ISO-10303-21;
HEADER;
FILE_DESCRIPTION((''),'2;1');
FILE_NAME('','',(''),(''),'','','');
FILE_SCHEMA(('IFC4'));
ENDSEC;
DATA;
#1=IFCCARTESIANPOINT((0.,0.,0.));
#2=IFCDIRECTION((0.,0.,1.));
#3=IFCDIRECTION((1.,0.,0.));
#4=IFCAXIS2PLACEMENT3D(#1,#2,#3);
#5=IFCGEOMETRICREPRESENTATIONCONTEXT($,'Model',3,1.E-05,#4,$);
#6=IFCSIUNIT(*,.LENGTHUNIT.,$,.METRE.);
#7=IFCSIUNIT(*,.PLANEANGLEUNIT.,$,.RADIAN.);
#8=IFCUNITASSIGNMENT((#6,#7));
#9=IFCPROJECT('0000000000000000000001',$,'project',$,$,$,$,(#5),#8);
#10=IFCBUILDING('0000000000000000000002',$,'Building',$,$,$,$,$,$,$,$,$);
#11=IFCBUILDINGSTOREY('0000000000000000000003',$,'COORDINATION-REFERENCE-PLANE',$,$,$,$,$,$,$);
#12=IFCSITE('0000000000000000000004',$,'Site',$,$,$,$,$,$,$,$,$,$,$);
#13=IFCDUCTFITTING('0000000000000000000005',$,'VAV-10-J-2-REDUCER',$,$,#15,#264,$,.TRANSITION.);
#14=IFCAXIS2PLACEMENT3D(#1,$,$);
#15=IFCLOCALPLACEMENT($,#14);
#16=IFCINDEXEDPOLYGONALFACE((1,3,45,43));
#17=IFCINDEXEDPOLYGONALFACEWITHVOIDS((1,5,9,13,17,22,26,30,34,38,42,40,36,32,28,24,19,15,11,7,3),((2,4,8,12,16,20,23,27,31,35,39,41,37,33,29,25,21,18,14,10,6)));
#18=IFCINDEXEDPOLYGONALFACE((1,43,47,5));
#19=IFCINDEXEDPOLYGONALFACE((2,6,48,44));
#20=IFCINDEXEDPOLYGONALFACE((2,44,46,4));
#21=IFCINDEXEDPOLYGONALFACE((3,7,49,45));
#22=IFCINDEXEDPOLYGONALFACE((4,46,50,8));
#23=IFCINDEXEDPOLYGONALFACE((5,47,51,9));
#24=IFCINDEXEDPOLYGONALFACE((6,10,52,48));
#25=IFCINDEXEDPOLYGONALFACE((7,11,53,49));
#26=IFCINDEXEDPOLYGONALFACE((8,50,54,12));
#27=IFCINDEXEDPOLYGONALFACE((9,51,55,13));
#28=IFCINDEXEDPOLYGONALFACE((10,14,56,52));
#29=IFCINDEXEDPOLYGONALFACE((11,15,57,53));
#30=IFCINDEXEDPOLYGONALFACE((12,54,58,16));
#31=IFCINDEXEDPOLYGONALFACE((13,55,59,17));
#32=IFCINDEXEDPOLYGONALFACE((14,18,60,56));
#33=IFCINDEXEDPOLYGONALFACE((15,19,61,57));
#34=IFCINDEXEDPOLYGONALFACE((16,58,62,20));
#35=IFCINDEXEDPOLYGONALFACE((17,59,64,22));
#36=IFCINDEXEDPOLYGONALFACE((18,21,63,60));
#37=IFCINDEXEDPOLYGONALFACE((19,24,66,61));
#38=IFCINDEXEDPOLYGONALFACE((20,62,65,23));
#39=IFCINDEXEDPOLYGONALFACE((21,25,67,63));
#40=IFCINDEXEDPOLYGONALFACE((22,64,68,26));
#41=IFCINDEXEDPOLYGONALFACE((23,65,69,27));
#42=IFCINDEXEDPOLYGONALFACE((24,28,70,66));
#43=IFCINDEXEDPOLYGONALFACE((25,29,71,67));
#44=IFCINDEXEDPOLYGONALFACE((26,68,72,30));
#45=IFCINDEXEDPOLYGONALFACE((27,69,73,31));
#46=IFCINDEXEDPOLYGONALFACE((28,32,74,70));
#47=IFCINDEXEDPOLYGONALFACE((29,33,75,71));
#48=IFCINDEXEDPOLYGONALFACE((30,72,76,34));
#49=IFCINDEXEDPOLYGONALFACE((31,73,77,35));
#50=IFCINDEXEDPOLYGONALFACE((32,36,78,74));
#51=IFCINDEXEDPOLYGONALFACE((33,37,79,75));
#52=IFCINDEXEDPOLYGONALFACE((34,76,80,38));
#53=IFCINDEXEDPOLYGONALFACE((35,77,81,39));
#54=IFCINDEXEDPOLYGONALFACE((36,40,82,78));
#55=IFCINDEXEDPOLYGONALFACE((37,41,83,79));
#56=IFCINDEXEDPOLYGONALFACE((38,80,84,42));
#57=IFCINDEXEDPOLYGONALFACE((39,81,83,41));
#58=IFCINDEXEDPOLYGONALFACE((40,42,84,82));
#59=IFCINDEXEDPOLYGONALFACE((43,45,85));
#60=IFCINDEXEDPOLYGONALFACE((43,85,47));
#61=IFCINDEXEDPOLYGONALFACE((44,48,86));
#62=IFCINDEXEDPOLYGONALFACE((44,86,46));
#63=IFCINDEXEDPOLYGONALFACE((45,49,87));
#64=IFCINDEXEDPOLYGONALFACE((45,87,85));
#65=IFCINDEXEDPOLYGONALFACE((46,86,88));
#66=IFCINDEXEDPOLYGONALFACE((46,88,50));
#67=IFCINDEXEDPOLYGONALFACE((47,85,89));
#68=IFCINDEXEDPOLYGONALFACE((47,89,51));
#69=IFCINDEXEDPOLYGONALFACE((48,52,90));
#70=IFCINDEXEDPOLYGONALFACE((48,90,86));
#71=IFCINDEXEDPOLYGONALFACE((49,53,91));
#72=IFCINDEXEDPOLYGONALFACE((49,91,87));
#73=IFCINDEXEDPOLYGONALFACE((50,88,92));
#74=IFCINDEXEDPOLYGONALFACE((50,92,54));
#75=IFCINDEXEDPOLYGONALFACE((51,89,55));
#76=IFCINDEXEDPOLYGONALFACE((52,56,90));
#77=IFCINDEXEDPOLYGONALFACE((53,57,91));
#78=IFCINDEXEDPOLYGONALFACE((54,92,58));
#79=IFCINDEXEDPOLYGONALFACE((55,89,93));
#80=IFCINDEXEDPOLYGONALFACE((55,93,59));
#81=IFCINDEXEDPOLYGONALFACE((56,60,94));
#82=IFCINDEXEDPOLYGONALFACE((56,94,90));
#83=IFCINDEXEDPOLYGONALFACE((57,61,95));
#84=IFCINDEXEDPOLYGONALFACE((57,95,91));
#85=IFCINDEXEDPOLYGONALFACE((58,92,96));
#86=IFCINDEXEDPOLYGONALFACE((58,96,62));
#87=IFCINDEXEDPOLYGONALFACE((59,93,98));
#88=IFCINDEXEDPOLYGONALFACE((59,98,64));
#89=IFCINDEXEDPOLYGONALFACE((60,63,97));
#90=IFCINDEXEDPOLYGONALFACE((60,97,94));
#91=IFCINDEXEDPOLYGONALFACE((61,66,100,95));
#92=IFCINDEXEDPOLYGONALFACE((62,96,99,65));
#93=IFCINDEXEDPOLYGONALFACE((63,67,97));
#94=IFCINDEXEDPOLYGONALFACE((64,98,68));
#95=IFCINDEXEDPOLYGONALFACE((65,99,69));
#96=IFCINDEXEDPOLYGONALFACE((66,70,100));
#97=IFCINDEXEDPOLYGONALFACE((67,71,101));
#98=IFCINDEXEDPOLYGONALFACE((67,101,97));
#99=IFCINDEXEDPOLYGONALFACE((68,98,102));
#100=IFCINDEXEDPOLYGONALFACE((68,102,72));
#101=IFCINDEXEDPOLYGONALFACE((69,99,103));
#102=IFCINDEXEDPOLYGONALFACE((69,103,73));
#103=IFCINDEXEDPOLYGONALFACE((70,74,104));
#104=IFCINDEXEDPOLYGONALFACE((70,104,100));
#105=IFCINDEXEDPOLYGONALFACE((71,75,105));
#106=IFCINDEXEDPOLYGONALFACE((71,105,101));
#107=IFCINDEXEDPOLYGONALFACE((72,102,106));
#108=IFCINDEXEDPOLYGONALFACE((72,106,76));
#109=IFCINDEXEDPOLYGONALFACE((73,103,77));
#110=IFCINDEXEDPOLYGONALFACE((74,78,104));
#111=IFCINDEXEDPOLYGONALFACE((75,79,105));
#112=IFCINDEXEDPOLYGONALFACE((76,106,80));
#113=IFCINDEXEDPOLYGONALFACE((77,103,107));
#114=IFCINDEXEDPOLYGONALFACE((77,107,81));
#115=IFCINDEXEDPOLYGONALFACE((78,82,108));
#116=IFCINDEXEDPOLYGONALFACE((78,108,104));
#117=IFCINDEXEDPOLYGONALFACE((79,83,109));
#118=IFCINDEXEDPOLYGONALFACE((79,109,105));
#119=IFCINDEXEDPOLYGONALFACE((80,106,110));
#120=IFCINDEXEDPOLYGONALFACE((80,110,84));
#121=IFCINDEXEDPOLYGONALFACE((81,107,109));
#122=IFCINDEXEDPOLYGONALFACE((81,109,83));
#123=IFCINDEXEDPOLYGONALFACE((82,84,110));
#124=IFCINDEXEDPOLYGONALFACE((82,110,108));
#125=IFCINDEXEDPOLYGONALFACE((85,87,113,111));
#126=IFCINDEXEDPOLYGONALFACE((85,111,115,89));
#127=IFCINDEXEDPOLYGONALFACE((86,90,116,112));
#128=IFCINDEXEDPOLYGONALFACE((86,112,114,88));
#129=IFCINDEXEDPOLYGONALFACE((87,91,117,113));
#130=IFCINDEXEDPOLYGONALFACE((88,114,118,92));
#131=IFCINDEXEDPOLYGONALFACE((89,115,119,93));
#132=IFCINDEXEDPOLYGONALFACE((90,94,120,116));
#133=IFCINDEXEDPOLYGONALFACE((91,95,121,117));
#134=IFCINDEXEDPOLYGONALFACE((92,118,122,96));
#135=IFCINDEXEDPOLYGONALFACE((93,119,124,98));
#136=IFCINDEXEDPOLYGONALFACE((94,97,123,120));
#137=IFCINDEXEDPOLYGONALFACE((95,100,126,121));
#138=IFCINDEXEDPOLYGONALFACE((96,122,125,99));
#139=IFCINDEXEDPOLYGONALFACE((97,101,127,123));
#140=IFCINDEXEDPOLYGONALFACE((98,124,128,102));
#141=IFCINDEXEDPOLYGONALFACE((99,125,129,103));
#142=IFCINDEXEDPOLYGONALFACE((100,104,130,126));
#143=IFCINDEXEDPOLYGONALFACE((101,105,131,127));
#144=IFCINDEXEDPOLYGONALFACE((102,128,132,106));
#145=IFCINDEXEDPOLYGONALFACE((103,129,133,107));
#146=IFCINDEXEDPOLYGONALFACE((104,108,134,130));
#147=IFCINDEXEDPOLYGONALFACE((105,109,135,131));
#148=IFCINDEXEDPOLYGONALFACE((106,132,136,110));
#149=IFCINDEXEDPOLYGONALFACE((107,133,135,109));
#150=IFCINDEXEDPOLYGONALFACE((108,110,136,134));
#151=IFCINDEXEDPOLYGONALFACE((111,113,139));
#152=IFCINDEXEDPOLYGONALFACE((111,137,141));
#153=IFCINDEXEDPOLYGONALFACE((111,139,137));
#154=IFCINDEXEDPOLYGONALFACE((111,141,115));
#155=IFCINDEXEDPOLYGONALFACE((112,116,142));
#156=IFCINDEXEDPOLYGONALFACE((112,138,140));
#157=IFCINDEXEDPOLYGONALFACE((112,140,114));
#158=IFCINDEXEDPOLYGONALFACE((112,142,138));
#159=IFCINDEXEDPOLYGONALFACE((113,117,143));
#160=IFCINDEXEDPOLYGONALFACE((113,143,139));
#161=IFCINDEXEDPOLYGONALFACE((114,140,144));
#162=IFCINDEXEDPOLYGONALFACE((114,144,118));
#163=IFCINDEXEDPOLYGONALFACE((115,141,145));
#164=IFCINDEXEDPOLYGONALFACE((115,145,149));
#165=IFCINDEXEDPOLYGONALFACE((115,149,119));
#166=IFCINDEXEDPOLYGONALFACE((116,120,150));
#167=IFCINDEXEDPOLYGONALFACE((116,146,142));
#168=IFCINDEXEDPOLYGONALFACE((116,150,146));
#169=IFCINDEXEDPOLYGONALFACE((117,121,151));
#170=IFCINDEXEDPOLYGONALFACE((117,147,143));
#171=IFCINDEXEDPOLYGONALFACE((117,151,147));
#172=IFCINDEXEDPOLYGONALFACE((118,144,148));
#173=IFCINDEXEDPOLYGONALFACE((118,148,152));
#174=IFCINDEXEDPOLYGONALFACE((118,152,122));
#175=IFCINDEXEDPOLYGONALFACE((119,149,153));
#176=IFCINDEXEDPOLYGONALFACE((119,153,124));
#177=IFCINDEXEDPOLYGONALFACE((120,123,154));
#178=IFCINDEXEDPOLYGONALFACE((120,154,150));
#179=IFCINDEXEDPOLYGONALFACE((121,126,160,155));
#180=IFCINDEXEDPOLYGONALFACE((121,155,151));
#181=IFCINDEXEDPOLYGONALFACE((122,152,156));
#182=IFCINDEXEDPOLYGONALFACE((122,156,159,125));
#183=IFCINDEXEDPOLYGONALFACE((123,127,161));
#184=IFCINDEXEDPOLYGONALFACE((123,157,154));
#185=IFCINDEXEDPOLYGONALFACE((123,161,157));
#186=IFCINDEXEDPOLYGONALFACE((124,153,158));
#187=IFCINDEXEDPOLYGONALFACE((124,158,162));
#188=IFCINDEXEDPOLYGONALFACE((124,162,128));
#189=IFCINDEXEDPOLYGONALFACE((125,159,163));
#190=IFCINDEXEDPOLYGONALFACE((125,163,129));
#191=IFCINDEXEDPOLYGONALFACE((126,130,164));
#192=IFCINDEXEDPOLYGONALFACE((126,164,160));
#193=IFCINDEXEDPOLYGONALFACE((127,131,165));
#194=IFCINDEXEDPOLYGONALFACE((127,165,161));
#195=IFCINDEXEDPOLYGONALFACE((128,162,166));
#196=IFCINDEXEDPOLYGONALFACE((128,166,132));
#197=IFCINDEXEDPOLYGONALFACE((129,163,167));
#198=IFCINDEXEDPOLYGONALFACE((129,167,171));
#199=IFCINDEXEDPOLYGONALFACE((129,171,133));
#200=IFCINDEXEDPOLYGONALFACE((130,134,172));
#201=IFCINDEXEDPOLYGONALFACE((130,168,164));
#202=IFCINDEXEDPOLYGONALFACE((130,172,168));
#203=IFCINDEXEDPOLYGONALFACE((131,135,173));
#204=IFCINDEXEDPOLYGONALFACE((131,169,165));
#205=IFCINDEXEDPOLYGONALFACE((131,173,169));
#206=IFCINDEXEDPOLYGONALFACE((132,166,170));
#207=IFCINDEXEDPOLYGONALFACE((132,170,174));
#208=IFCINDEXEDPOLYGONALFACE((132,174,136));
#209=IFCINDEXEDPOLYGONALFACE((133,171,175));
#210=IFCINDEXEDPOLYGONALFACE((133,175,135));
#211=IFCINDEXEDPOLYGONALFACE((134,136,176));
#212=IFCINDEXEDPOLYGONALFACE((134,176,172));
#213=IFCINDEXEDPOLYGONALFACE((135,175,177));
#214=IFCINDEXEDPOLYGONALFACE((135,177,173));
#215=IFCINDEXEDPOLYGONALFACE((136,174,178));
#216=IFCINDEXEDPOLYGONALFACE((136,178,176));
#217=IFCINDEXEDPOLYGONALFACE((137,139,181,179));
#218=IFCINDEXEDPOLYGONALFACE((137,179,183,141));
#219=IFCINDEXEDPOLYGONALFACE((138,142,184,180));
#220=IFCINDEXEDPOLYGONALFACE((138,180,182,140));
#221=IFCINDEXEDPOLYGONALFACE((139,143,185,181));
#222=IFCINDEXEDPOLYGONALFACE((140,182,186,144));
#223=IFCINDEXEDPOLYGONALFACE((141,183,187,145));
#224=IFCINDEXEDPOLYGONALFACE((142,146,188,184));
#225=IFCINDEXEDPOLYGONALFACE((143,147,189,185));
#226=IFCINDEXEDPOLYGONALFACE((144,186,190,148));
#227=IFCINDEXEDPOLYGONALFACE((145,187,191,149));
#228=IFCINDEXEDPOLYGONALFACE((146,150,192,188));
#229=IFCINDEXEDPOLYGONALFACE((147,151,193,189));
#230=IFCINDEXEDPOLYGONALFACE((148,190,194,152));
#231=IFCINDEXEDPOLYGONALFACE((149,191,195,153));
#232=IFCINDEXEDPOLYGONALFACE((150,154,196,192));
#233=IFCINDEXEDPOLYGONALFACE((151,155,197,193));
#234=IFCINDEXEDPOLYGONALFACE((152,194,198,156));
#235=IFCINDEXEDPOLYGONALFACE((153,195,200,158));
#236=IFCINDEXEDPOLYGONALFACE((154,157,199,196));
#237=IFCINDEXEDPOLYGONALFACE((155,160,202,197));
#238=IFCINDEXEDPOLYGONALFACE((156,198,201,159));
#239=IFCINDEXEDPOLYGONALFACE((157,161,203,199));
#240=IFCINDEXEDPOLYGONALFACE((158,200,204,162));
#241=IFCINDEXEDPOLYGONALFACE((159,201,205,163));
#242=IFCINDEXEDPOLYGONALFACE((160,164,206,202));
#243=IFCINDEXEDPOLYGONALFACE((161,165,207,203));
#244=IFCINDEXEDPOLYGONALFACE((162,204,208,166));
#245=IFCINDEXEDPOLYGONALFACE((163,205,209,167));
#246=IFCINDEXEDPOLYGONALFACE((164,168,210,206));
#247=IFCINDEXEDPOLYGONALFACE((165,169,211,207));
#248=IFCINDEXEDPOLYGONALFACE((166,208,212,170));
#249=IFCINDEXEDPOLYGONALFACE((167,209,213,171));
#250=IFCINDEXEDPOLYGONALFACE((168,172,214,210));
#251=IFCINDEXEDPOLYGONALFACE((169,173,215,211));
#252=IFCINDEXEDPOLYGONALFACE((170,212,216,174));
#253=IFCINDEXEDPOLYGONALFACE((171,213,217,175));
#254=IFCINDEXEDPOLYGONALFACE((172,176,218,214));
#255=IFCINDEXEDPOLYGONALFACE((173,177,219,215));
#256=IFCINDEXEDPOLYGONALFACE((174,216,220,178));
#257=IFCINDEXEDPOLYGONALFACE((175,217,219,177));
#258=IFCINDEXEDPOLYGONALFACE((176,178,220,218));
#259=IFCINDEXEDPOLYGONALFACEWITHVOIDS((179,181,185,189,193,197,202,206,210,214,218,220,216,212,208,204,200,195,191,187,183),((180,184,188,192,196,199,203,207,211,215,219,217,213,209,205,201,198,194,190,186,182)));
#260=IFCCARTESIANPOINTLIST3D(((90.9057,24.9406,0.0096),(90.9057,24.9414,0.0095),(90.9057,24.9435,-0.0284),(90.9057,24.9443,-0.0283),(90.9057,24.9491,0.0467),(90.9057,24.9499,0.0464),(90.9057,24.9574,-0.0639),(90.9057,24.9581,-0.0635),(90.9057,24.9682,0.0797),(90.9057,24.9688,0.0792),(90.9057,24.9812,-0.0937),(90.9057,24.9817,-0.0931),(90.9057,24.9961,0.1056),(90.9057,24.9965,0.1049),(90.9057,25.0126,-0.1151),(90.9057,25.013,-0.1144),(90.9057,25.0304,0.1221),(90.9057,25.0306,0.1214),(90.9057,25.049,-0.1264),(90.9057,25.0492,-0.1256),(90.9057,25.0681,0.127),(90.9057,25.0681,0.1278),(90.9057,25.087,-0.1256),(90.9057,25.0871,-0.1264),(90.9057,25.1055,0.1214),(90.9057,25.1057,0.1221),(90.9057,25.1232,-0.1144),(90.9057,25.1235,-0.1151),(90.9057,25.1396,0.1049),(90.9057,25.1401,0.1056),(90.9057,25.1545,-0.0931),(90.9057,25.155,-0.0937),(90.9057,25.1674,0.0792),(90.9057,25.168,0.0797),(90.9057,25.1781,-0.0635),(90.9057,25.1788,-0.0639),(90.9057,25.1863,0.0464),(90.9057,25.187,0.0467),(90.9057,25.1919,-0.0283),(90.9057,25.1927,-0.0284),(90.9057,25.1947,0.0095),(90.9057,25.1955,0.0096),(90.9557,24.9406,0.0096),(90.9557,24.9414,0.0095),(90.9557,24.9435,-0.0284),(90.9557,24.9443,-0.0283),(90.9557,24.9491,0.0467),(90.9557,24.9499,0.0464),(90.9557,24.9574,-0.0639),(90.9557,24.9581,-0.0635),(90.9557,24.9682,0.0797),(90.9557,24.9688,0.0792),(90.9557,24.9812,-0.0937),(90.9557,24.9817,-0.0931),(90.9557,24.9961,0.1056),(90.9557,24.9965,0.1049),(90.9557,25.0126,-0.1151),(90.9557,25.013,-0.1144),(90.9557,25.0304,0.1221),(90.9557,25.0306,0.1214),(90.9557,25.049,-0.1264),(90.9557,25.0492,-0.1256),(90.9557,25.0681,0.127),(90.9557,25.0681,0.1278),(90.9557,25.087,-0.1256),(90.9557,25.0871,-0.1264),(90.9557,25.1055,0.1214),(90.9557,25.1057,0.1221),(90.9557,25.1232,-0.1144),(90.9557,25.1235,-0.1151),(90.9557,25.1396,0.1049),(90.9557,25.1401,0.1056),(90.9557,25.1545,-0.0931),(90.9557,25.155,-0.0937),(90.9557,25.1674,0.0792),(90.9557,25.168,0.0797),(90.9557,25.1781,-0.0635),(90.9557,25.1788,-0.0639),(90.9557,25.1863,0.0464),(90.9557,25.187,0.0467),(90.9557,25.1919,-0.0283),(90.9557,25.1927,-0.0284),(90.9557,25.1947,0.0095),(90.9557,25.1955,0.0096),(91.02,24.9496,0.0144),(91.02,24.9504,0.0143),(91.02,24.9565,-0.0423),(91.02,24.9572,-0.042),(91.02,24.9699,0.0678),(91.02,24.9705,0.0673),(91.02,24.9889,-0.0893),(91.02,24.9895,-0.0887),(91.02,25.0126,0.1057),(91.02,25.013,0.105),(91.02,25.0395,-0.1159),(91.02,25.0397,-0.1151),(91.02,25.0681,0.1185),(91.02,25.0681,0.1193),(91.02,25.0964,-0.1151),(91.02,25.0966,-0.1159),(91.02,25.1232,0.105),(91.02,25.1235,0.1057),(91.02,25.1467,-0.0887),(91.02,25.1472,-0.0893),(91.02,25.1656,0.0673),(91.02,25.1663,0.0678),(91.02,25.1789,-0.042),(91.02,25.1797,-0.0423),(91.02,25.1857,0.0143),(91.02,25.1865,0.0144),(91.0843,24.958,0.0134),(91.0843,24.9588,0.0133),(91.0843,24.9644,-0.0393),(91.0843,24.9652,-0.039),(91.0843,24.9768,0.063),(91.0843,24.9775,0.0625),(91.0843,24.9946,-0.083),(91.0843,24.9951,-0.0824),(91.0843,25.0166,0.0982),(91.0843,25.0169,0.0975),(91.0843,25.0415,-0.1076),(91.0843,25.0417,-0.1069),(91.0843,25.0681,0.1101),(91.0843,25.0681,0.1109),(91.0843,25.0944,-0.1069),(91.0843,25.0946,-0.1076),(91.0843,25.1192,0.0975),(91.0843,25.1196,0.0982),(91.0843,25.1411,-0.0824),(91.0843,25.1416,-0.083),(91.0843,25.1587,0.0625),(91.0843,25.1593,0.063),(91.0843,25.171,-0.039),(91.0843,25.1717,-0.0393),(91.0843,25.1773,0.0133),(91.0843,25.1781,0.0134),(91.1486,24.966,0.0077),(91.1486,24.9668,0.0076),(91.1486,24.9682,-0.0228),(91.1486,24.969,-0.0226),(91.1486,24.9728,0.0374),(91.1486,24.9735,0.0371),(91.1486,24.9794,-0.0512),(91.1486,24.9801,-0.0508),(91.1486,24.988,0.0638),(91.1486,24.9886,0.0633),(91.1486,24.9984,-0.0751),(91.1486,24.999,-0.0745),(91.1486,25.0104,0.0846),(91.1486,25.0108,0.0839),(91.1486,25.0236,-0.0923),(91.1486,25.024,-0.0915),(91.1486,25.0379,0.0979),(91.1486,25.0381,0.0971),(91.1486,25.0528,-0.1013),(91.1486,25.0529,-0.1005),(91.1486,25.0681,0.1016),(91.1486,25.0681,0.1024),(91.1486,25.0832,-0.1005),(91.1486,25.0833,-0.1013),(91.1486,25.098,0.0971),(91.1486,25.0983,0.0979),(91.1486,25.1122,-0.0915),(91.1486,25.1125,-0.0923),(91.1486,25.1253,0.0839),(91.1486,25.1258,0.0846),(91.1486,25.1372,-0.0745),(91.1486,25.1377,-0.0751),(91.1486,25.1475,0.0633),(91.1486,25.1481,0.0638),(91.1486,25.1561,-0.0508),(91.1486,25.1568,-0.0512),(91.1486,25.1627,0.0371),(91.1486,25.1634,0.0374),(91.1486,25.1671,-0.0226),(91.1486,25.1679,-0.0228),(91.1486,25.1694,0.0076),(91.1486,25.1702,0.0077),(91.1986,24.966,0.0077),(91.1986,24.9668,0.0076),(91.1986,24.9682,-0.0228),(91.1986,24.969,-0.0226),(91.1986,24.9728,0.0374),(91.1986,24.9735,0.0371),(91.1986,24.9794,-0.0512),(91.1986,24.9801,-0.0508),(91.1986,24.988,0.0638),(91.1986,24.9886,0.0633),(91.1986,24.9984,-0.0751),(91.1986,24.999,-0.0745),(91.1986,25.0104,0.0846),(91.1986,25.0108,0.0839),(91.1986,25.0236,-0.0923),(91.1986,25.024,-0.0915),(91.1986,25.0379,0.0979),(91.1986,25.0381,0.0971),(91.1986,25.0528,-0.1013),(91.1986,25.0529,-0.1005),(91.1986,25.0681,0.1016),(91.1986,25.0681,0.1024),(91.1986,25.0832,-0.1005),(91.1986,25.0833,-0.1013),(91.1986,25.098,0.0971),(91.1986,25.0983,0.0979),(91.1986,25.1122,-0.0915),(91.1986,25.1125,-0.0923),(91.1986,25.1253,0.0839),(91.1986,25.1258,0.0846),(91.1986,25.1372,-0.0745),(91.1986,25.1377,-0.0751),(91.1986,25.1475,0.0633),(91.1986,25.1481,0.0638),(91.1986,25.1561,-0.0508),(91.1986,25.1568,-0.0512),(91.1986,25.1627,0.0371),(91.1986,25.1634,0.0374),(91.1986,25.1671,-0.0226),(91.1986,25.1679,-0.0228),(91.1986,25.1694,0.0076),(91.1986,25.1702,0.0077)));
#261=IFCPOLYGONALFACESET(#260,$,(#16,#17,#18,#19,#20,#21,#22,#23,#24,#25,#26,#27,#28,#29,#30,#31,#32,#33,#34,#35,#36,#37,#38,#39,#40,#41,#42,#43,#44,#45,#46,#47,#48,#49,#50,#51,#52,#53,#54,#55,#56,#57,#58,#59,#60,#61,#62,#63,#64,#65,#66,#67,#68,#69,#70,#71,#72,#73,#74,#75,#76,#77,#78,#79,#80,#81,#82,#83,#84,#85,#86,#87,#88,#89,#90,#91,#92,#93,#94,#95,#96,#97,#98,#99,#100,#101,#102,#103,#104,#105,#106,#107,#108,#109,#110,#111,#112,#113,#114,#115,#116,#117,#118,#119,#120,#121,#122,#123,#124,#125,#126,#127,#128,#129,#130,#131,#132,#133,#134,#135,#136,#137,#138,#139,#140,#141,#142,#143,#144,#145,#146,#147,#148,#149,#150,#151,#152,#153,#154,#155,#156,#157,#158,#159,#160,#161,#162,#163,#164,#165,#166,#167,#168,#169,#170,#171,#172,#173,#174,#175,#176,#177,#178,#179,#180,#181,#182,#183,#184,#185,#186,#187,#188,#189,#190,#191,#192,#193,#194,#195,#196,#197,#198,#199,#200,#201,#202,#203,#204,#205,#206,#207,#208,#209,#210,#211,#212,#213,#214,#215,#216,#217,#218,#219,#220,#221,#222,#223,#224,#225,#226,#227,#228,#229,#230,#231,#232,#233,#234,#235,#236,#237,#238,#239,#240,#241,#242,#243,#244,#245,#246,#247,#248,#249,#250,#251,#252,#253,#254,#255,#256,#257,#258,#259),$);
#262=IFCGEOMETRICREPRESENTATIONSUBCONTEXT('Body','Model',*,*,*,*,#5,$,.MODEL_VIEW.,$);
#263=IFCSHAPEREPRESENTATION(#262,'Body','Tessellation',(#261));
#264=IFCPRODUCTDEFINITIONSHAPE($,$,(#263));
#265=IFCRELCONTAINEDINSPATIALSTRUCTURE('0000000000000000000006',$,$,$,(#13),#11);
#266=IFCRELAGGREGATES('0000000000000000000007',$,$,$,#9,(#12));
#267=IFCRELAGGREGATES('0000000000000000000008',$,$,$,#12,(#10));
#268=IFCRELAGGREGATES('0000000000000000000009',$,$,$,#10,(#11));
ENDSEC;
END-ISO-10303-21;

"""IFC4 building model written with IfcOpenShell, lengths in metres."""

from ifc_helpers import new_model, entity, si_unit, frame, origin_with_axes, place, context, subcontext, project, spatial, element, save


model = new_model("IFC4")

# Units and contexts
model_context = context("Model", 3, precision=1e-05, world=origin_with_axes())
body_context_1 = subcontext(model_context, "Body", "Model", "MODEL_VIEW")
ifc_project = project(units=[si_unit("LENGTHUNIT", "METRE"), si_unit("PLANEANGLEUNIT", "RADIAN")], contexts=[model_context])

# Site, building, storey
site = spatial("IfcSite", under=ifc_project, Name="Site")
building = spatial("IfcBuilding", under=site, Name="Building")
storey = spatial("IfcBuildingStorey", under=building, Name="COORDINATION-REFERENCE-PLANE")

# Duct fitting
for number, where, z_axis, x_axis, name in (
    (1, (90.9057, 25.0681, 0.0), (0.0, 1.0, 0.0), (0.0, 0.0, 1.0), "VAV-10-J-2-REDUCER"),
):
    element("IfcDuctFitting", number, at=place(None, frame(where, z_axis=z_axis, x_axis=x_axis)), inside=storey, Name=name, PredefinedType="TRANSITION", context=body_context_1, shape_type="SweptSolid", body=[
        entity("IfcRevolvedAreaSolid", entity("IfcArbitraryClosedProfileDef", "AREA", None, entity("IfcPolyline", [entity("IfcCartesianPoint", [0.1278, 0.0]), entity("IfcCartesianPoint", [0.1278, 0.05]), entity("IfcCartesianPoint", [0.1024, 0.2429]), entity("IfcCartesianPoint", [0.1024, 0.2929]), entity("IfcCartesianPoint", [0.1016, 0.2929]), entity("IfcCartesianPoint", [0.1016, 0.2429]), entity("IfcCartesianPoint", [0.127, 0.05]), entity("IfcCartesianPoint", [0.127, 0.0]), entity("IfcCartesianPoint", [0.1278, 0.0])])), entity("IfcAxis2Placement3D", entity("IfcCartesianPoint", [0.0, 0.0, 0.0])), entity("IfcAxis1Placement", entity("IfcCartesianPoint", [0.0, 0.0, 0.0]), entity("IfcDirection", [0.0, 1.0, 0.0])), 6.283185),
    ])

save(model, "model.ifc")
